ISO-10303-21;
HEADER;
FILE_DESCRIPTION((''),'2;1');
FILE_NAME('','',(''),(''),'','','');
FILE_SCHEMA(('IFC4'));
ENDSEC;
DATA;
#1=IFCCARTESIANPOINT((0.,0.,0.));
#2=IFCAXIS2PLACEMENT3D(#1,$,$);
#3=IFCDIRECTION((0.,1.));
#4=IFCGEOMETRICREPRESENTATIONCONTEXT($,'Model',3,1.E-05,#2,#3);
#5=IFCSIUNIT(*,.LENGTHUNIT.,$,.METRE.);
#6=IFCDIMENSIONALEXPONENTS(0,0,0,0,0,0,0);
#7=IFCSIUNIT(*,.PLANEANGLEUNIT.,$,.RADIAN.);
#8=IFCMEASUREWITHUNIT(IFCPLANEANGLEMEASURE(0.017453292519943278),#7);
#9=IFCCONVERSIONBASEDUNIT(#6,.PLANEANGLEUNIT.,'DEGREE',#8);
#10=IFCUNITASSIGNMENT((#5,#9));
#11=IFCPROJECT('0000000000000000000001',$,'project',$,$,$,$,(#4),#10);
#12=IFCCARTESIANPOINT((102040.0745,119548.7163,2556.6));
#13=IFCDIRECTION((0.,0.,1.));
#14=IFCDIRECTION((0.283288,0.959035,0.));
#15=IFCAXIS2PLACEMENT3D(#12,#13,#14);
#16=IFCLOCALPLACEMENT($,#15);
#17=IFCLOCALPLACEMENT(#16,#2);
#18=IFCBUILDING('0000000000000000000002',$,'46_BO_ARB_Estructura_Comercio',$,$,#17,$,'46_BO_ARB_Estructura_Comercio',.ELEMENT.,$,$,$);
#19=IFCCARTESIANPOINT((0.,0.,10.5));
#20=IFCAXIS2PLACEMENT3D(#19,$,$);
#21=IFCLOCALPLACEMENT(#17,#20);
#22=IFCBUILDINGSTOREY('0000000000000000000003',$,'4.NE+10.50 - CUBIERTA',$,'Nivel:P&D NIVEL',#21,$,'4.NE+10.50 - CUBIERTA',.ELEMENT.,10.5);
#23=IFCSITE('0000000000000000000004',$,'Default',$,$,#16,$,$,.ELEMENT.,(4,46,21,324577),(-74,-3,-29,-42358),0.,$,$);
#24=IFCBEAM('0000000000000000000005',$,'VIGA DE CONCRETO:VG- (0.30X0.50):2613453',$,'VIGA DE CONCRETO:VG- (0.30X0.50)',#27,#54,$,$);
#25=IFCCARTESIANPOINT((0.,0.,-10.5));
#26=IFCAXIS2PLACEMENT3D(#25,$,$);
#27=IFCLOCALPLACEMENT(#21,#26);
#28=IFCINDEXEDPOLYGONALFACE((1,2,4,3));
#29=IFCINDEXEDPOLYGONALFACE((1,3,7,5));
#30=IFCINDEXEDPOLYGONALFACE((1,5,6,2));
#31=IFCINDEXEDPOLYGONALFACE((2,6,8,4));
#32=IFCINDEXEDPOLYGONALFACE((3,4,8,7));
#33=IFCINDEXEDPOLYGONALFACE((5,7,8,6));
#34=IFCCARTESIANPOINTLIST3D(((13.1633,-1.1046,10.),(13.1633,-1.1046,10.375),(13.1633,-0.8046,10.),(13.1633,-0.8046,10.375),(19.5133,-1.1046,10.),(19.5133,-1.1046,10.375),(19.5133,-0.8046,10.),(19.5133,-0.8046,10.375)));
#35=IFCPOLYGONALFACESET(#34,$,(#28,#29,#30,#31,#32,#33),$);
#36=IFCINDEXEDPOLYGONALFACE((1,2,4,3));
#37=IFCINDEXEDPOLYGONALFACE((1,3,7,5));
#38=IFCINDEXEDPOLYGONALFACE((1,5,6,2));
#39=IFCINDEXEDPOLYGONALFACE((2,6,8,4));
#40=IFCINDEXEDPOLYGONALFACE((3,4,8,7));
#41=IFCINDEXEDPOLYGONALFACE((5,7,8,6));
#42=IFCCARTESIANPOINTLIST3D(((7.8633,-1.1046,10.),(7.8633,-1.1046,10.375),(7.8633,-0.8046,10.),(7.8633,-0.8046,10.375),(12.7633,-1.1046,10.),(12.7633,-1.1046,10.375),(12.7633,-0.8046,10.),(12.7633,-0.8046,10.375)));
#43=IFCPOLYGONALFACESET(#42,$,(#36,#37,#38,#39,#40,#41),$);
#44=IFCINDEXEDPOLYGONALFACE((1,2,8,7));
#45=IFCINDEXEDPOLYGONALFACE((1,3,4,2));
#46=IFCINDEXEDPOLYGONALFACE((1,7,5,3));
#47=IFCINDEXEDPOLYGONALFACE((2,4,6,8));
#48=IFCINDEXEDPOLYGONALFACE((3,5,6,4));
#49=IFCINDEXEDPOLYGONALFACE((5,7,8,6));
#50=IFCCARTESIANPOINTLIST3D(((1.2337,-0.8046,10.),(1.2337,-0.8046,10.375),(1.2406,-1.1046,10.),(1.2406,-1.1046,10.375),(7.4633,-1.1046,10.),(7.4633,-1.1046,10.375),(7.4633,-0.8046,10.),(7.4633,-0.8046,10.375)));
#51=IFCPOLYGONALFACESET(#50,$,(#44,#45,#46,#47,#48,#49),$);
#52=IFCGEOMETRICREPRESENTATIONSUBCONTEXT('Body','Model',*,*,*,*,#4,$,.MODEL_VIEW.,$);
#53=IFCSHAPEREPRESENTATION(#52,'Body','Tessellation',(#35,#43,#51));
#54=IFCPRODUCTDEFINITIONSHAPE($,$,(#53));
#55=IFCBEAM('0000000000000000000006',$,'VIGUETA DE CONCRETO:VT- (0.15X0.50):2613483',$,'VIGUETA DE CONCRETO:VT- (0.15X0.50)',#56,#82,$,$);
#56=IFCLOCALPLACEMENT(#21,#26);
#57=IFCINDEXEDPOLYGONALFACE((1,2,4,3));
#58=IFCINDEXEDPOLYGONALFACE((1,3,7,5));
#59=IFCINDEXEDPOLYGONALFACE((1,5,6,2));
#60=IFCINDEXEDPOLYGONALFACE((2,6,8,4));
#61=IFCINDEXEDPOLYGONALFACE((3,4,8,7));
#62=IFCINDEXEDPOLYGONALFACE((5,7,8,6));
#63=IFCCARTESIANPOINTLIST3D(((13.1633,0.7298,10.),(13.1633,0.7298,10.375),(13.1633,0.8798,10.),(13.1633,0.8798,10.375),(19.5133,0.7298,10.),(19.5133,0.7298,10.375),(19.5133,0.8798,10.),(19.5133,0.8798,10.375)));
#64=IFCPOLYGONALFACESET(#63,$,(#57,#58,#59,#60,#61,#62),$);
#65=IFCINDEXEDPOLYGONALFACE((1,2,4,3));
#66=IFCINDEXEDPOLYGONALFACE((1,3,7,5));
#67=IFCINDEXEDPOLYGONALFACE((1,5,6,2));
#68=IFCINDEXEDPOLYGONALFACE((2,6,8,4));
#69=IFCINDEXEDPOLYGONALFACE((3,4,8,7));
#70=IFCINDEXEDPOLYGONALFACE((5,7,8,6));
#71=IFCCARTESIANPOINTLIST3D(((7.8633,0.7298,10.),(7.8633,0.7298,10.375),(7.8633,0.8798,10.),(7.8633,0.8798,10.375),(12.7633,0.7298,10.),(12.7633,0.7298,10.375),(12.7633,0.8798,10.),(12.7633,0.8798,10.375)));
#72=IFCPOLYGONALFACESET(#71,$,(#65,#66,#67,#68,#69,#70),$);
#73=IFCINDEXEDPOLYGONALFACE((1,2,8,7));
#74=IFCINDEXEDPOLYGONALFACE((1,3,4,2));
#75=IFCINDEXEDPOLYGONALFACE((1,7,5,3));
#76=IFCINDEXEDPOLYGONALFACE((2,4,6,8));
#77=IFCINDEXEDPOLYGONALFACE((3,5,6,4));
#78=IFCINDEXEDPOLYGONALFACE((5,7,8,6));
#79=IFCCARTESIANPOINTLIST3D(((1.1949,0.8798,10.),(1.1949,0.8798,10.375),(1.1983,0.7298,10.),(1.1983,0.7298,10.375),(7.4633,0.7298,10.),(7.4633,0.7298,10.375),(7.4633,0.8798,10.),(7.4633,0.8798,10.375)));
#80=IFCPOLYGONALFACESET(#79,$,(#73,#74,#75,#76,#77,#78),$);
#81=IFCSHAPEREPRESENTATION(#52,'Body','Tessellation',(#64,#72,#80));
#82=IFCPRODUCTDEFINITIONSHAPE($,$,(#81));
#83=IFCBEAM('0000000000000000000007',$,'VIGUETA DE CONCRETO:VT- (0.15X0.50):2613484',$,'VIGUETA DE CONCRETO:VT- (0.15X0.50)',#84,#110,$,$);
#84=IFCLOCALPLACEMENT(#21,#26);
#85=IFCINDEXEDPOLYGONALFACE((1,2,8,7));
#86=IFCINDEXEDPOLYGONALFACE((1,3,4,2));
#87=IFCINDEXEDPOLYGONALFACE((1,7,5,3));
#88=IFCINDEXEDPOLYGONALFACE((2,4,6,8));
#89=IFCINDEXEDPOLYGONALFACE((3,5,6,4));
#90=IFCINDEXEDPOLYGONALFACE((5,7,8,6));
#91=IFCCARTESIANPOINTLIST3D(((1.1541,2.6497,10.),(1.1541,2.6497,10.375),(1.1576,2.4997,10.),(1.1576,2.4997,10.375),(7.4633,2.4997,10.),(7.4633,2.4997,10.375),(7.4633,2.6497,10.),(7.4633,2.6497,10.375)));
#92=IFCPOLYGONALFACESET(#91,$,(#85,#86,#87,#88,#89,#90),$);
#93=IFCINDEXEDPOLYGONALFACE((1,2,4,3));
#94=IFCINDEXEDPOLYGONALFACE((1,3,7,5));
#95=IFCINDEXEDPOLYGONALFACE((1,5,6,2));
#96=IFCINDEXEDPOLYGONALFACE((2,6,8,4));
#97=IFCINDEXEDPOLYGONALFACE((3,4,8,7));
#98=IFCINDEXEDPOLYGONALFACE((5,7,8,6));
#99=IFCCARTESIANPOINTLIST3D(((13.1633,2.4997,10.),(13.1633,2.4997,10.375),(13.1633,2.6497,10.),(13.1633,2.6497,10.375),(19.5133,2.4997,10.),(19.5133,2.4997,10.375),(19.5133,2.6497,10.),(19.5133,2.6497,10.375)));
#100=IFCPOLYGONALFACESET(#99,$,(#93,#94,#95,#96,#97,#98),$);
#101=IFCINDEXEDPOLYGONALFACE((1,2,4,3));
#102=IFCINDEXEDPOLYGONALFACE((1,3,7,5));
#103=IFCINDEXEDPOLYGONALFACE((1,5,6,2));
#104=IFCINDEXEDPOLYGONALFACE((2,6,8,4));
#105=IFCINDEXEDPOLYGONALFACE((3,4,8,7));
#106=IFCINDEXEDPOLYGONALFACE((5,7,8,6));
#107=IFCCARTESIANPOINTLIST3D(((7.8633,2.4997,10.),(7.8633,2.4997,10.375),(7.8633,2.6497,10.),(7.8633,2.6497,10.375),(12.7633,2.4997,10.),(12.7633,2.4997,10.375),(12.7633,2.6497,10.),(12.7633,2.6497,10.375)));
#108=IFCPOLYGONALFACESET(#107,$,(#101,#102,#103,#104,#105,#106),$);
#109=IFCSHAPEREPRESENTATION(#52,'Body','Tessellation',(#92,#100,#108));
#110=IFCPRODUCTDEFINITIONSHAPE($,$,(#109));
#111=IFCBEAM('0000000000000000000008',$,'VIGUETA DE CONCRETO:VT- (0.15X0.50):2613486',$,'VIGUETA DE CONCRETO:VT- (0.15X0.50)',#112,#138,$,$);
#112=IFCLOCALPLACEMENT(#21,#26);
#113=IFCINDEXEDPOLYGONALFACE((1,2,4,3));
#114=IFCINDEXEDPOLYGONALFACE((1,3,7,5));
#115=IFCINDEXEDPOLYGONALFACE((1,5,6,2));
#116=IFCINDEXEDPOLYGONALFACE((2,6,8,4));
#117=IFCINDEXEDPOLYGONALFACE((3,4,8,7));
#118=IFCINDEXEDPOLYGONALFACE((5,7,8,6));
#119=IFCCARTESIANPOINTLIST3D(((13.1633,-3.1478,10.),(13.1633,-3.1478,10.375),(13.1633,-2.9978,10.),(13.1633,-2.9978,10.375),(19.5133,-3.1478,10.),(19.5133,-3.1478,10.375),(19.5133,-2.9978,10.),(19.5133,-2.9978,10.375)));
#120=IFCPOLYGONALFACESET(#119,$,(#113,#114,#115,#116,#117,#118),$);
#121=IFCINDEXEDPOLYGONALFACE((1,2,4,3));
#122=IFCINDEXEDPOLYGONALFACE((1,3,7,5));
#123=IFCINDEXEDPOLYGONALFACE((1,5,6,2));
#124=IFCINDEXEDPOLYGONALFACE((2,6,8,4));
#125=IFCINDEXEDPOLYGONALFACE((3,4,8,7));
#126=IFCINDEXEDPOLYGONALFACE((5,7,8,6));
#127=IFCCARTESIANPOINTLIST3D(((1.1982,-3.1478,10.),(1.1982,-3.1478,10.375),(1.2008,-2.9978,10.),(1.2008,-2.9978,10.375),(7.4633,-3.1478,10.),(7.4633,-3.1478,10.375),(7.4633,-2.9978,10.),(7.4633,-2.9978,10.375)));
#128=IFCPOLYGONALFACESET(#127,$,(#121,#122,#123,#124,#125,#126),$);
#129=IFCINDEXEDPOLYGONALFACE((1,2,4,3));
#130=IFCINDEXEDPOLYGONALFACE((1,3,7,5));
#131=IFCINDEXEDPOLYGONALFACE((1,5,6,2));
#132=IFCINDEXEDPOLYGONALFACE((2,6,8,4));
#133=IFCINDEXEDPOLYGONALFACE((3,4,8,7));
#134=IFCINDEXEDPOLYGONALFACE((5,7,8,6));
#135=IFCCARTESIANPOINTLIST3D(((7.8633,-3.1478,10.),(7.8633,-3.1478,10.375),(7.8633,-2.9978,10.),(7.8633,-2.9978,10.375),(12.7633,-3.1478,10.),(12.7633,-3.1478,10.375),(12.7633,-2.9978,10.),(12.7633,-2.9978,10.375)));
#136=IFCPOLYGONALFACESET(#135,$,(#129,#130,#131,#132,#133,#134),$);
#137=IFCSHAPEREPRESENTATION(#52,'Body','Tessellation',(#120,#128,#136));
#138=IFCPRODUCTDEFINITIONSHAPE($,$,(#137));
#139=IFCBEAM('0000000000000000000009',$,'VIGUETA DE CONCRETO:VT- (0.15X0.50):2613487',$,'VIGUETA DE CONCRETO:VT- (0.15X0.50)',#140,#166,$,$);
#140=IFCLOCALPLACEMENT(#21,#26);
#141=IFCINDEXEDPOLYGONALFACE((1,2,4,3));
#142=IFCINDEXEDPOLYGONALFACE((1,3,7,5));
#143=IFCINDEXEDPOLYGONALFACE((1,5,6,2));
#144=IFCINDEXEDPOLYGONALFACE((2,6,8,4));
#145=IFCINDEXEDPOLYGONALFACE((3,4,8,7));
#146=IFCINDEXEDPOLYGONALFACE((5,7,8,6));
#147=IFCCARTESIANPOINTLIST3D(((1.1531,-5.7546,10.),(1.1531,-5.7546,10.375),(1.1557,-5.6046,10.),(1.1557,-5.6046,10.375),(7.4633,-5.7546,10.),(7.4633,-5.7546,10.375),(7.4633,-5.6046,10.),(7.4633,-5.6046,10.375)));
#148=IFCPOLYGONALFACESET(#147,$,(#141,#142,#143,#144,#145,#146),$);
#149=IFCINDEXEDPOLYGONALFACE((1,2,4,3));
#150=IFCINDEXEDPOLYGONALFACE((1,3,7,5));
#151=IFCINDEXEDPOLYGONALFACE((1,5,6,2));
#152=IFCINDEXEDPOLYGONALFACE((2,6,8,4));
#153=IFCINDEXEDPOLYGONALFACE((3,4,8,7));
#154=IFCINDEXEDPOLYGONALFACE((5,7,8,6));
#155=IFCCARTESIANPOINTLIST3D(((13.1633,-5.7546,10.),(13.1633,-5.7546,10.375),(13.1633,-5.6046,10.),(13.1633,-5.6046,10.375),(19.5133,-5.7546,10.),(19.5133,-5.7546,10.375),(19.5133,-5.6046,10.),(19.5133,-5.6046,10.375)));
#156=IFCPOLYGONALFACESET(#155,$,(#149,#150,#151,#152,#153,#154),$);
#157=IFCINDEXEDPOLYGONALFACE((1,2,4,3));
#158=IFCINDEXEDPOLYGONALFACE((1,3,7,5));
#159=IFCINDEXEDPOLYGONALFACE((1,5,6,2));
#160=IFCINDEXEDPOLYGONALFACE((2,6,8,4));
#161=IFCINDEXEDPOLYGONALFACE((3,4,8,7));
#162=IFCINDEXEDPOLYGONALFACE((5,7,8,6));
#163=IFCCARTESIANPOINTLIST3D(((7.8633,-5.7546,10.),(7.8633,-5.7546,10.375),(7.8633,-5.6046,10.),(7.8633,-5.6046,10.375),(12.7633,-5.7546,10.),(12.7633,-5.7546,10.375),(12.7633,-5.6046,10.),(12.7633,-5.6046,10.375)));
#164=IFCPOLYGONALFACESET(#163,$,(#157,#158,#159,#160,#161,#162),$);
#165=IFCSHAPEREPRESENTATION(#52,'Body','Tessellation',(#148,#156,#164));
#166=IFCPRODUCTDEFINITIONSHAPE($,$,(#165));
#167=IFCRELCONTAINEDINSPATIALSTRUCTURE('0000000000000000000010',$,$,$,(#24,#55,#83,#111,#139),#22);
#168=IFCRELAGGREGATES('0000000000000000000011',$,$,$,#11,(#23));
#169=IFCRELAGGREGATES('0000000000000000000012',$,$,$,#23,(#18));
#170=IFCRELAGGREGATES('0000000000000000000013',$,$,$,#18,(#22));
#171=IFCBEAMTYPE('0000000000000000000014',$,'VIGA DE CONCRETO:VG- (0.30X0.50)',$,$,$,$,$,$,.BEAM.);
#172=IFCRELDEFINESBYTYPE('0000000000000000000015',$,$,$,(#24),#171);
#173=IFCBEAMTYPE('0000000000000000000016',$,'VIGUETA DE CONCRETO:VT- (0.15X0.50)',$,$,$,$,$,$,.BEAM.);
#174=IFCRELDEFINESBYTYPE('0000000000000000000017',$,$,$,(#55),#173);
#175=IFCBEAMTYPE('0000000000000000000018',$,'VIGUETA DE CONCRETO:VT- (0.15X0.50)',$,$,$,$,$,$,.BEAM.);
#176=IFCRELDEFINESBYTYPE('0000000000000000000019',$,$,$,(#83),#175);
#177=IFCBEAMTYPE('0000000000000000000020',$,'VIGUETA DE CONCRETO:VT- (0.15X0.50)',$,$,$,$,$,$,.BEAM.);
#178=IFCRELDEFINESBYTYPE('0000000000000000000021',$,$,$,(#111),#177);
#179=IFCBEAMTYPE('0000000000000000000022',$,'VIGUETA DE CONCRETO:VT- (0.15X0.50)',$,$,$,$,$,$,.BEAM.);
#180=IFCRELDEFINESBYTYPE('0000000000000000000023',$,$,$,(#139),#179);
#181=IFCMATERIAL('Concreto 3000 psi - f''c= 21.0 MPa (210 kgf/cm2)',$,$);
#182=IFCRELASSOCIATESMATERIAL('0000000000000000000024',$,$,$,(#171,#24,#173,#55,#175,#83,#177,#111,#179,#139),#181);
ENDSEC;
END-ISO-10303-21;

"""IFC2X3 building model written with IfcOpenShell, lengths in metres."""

from ifc_helpers import new_model, entity, si_unit, converted_unit, direction, frame, frame_2d, origin, place, context, subcontext, project, spatial, rectangle, extrude, clip, halfspace, source, transform, mapped, material, type_object, type_shapes, element, save


model = new_model("IFC2X3")

# Units and contexts
model_context = context("Model", 3, precision=1e-05, world=origin(), true_north=direction((0.0, 1.0)))
body_context = subcontext(model_context, "Body", "Model", "MODEL_VIEW")
ifc_project = project(units=[si_unit("LENGTHUNIT", "METRE"), converted_unit("PLANEANGLEUNIT", "DEGREE", entity("IfcPlaneAngleMeasure", 0.017453292519943278), si_unit("PLANEANGLEUNIT", "RADIAN"), dimensions=[0, 0, 0, 0, 0, 0, 0])], contexts=[model_context])

# Site, building, storey
site_placement = place(None, frame((102040.0745, 119548.7163, 2556.6), z_axis=(0.0, 0.0, 1.0), x_axis=(0.283288, 0.959035, 0.0)))
site = spatial("IfcSite", under=ifc_project, at=site_placement, Name="Default", CompositionType="ELEMENT", RefLatitude=(4, 46, 21, 324577), RefLongitude=(-74, -3, -29, -42358), RefElevation=0.0)
building_placement = place(site_placement, origin())
building = spatial("IfcBuilding", under=site, at=building_placement, Name="46_BO_ARB_Estructura_Comercio", LongName="46_BO_ARB_Estructura_Comercio", CompositionType="ELEMENT")
storey_placement = place(building_placement, frame((0.0, 0.0, 10.5)))
storey = spatial("IfcBuildingStorey", under=building, at=storey_placement, Name="4.NE+10.50 - CUBIERTA", ObjectType="Nivel:P&D NIVEL", LongName="4.NE+10.50 - CUBIERTA", CompositionType="ELEMENT", Elevation=10.5)

# Beams
ifc_material = material(Name="Concreto 3000 psi - f'c= 21.0 MPa (210 kgf/cm2)")
beam_type_1 = type_object("IfcBeamType", Name="VIGA DE CONCRETO:VG- (0.30X0.50)", PredefinedType="BEAM", material=ifc_material)
shared_shape_1 = source(origin(), body_context, "Body", "SweptSolid", [
    extrude(rectangle(XDim=0.375, YDim=0.3, at=frame_2d((0.0, 0.0), x_axis=(1.0, 0.0))), frame((13.1633, -0.9546, 10.1875), z_axis=(1.0, 0.0, 0.0), x_axis=(0.0, 0.0, -1.0)), (0.0, 0.0, 1.0), 6.35),
    extrude(rectangle(XDim=0.375, YDim=0.3, at=frame_2d((0.0, 0.0), x_axis=(1.0, 0.0))), frame((7.8633, -0.9546, 10.1875), z_axis=(1.0, 0.0, 0.0), x_axis=(0.0, 0.0, -1.0)), (0.0, 0.0, 1.0), 4.9),
    clip(extrude(rectangle(XDim=0.375, YDim=0.3, at=frame_2d((0.0, 0.0), x_axis=(1.0, 0.0))), frame((1.2337, -0.9546, 10.1875), z_axis=(1.0, 0.0, 0.0), x_axis=(0.0, 0.0, -1.0)), (0.0, 0.0, 1.0), 6.2296), halfspace(frame((1.1171, 4.257, 10.5), z_axis=(-0.999735, -0.023028, 0.0), x_axis=(0.023028, -0.999735, 0.0)), False)),
])
type_shapes(beam_type_1, [shared_shape_1])
beam_1_placement = place(storey_placement, frame((0.0, 0.0, -10.5)))
element("IfcBeam", 1, at=beam_1_placement, inside=storey, type_object=beam_type_1, material=ifc_material, Name="VIGA DE CONCRETO:VG- (0.30X0.50):2613453", ObjectType="VIGA DE CONCRETO:VG- (0.30X0.50)", context=body_context, shape_type="MappedRepresentation", body=[
    mapped(shared_shape_1, transform((0.0, 0.0, 0.0), scale=1.0)),
])
beam_type_2 = type_object("IfcBeamType", Name="VIGUETA DE CONCRETO:VT- (0.15X0.50)", PredefinedType="BEAM", material=ifc_material)
shared_shape_2 = source(origin(), body_context, "Body", "SweptSolid", [
    extrude(rectangle(XDim=0.375, YDim=0.15, at=frame_2d((0.0, 0.0), x_axis=(1.0, 0.0))), frame((13.1633, 0.8048, 10.1875), z_axis=(1.0, 0.0, 0.0), x_axis=(0.0, 0.0, -1.0)), (0.0, 0.0, 1.0), 6.35),
    extrude(rectangle(XDim=0.375, YDim=0.15, at=frame_2d((0.0, 0.0), x_axis=(1.0, 0.0))), frame((7.8633, 0.8048, 10.1875), z_axis=(1.0, 0.0, 0.0), x_axis=(0.0, 0.0, -1.0)), (0.0, 0.0, 1.0), 4.9),
    clip(extrude(rectangle(XDim=0.375, YDim=0.15, at=frame_2d((0.0, 0.0), x_axis=(1.0, 0.0))), frame((1.1949, 0.8048, 10.1875), z_axis=(1.0, 0.0, 0.0), x_axis=(0.0, 0.0, -1.0)), (0.0, 0.0, 1.0), 6.2684), halfspace(frame((1.1171, 4.257, 10.5), z_axis=(-0.999735, -0.023028, 0.0), x_axis=(0.023028, -0.999735, 0.0)), False)),
])
type_shapes(beam_type_2, [shared_shape_2])
beam_2_placement = place(storey_placement, frame((0.0, 0.0, -10.5)))
element("IfcBeam", 2, at=beam_2_placement, inside=storey, type_object=beam_type_2, material=ifc_material, Name="VIGUETA DE CONCRETO:VT- (0.15X0.50):2613483", ObjectType="VIGUETA DE CONCRETO:VT- (0.15X0.50)", context=body_context, shape_type="MappedRepresentation", body=[
    mapped(shared_shape_2, transform((0.0, 0.0, 0.0), scale=1.0)),
])
beam_type_3 = type_object("IfcBeamType", Name="VIGUETA DE CONCRETO:VT- (0.15X0.50)", PredefinedType="BEAM", material=ifc_material)
shared_shape_3 = source(origin(), body_context, "Body", "SweptSolid", [
    clip(extrude(rectangle(XDim=0.375, YDim=0.15, at=frame_2d((0.0, 0.0), x_axis=(1.0, 0.0))), frame((1.1541, 2.5747, 10.1875), z_axis=(1.0, 0.0, 0.0), x_axis=(0.0, 0.0, -1.0)), (0.0, 0.0, 1.0), 6.3092), halfspace(frame((1.1171, 4.257, 10.5), z_axis=(-0.999735, -0.023028, 0.0), x_axis=(0.023028, -0.999735, 0.0)), False)),
    extrude(rectangle(XDim=0.375, YDim=0.15, at=frame_2d((0.0, 0.0), x_axis=(1.0, 0.0))), frame((13.1633, 2.5747, 10.1875), z_axis=(1.0, 0.0, 0.0), x_axis=(0.0, 0.0, -1.0)), (0.0, 0.0, 1.0), 6.35),
    extrude(rectangle(XDim=0.375, YDim=0.15, at=frame_2d((0.0, 0.0), x_axis=(1.0, 0.0))), frame((7.8633, 2.5747, 10.1875), z_axis=(1.0, 0.0, 0.0), x_axis=(0.0, 0.0, -1.0)), (0.0, 0.0, 1.0), 4.9),
])
type_shapes(beam_type_3, [shared_shape_3])
beam_3_placement = place(storey_placement, frame((0.0, 0.0, -10.5)))
element("IfcBeam", 3, at=beam_3_placement, inside=storey, type_object=beam_type_3, material=ifc_material, Name="VIGUETA DE CONCRETO:VT- (0.15X0.50):2613484", ObjectType="VIGUETA DE CONCRETO:VT- (0.15X0.50)", context=body_context, shape_type="MappedRepresentation", body=[
    mapped(shared_shape_3, transform((0.0, 0.0, 0.0), scale=1.0)),
])
beam_type_4 = type_object("IfcBeamType", Name="VIGUETA DE CONCRETO:VT- (0.15X0.50)", PredefinedType="BEAM", material=ifc_material)
shared_shape_4 = source(origin(), body_context, "Body", "SweptSolid", [
    extrude(rectangle(XDim=0.375, YDim=0.15, at=frame_2d((0.0, 0.0), x_axis=(1.0, 0.0))), frame((13.1633, -3.0728, 10.1875), z_axis=(1.0, 0.0, 0.0), x_axis=(0.0, 0.0, -1.0)), (0.0, 0.0, 1.0), 6.35),
    clip(extrude(rectangle(XDim=0.375, YDim=0.15, at=frame_2d((0.0, 0.0), x_axis=(1.0, 0.0))), frame((1.1982, -3.0728, 10.1875), z_axis=(1.0, 0.0, 0.0), x_axis=(0.0, 0.0, -1.0)), (0.0, 0.0, 1.0), 6.2651), halfspace(frame((1.2358, -0.9774, 10.5), z_axis=(-0.99985, 0.017293, 0.0), x_axis=(-0.017293, -0.99985, 0.0)), False)),
    extrude(rectangle(XDim=0.375, YDim=0.15, at=frame_2d((0.0, 0.0), x_axis=(1.0, 0.0))), frame((7.8633, -3.0728, 10.1875), z_axis=(1.0, 0.0, 0.0), x_axis=(0.0, 0.0, -1.0)), (0.0, 0.0, 1.0), 4.9),
])
type_shapes(beam_type_4, [shared_shape_4])
beam_4_placement = place(storey_placement, frame((0.0, 0.0, -10.5)))
element("IfcBeam", 4, at=beam_4_placement, inside=storey, type_object=beam_type_4, material=ifc_material, Name="VIGUETA DE CONCRETO:VT- (0.15X0.50):2613486", ObjectType="VIGUETA DE CONCRETO:VT- (0.15X0.50)", context=body_context, shape_type="MappedRepresentation", body=[
    mapped(shared_shape_4, transform((0.0, 0.0, 0.0), scale=1.0)),
])
beam_type_5 = type_object("IfcBeamType", Name="VIGUETA DE CONCRETO:VT- (0.15X0.50)", PredefinedType="BEAM", material=ifc_material)
shared_shape_5 = source(origin(), body_context, "Body", "SweptSolid", [
    clip(extrude(rectangle(XDim=0.375, YDim=0.15, at=frame_2d((0.0, 0.0), x_axis=(1.0, 0.0))), frame((1.1531, -5.6796, 10.1875), z_axis=(1.0, 0.0, 0.0), x_axis=(0.0, 0.0, -1.0)), (0.0, 0.0, 1.0), 6.3102), halfspace(frame((1.2358, -0.9774, 10.5), z_axis=(-0.99985, 0.017293, 0.0), x_axis=(-0.017293, -0.99985, 0.0)), False)),
    extrude(rectangle(XDim=0.375, YDim=0.15, at=frame_2d((0.0, 0.0), x_axis=(1.0, 0.0))), frame((13.1633, -5.6796, 10.1875), z_axis=(1.0, 0.0, 0.0), x_axis=(0.0, 0.0, -1.0)), (0.0, 0.0, 1.0), 6.35),
    extrude(rectangle(XDim=0.375, YDim=0.15, at=frame_2d((0.0, 0.0), x_axis=(1.0, 0.0))), frame((7.8633, -5.6796, 10.1875), z_axis=(1.0, 0.0, 0.0), x_axis=(0.0, 0.0, -1.0)), (0.0, 0.0, 1.0), 4.9),
])
type_shapes(beam_type_5, [shared_shape_5])
beam_5_placement = place(storey_placement, frame((0.0, 0.0, -10.5)))
element("IfcBeam", 5, at=beam_5_placement, inside=storey, type_object=beam_type_5, material=ifc_material, Name="VIGUETA DE CONCRETO:VT- (0.15X0.50):2613487", ObjectType="VIGUETA DE CONCRETO:VT- (0.15X0.50)", context=body_context, shape_type="MappedRepresentation", body=[
    mapped(shared_shape_5, transform((0.0, 0.0, 0.0), scale=1.0)),
])

save(model, "model.ifc")
